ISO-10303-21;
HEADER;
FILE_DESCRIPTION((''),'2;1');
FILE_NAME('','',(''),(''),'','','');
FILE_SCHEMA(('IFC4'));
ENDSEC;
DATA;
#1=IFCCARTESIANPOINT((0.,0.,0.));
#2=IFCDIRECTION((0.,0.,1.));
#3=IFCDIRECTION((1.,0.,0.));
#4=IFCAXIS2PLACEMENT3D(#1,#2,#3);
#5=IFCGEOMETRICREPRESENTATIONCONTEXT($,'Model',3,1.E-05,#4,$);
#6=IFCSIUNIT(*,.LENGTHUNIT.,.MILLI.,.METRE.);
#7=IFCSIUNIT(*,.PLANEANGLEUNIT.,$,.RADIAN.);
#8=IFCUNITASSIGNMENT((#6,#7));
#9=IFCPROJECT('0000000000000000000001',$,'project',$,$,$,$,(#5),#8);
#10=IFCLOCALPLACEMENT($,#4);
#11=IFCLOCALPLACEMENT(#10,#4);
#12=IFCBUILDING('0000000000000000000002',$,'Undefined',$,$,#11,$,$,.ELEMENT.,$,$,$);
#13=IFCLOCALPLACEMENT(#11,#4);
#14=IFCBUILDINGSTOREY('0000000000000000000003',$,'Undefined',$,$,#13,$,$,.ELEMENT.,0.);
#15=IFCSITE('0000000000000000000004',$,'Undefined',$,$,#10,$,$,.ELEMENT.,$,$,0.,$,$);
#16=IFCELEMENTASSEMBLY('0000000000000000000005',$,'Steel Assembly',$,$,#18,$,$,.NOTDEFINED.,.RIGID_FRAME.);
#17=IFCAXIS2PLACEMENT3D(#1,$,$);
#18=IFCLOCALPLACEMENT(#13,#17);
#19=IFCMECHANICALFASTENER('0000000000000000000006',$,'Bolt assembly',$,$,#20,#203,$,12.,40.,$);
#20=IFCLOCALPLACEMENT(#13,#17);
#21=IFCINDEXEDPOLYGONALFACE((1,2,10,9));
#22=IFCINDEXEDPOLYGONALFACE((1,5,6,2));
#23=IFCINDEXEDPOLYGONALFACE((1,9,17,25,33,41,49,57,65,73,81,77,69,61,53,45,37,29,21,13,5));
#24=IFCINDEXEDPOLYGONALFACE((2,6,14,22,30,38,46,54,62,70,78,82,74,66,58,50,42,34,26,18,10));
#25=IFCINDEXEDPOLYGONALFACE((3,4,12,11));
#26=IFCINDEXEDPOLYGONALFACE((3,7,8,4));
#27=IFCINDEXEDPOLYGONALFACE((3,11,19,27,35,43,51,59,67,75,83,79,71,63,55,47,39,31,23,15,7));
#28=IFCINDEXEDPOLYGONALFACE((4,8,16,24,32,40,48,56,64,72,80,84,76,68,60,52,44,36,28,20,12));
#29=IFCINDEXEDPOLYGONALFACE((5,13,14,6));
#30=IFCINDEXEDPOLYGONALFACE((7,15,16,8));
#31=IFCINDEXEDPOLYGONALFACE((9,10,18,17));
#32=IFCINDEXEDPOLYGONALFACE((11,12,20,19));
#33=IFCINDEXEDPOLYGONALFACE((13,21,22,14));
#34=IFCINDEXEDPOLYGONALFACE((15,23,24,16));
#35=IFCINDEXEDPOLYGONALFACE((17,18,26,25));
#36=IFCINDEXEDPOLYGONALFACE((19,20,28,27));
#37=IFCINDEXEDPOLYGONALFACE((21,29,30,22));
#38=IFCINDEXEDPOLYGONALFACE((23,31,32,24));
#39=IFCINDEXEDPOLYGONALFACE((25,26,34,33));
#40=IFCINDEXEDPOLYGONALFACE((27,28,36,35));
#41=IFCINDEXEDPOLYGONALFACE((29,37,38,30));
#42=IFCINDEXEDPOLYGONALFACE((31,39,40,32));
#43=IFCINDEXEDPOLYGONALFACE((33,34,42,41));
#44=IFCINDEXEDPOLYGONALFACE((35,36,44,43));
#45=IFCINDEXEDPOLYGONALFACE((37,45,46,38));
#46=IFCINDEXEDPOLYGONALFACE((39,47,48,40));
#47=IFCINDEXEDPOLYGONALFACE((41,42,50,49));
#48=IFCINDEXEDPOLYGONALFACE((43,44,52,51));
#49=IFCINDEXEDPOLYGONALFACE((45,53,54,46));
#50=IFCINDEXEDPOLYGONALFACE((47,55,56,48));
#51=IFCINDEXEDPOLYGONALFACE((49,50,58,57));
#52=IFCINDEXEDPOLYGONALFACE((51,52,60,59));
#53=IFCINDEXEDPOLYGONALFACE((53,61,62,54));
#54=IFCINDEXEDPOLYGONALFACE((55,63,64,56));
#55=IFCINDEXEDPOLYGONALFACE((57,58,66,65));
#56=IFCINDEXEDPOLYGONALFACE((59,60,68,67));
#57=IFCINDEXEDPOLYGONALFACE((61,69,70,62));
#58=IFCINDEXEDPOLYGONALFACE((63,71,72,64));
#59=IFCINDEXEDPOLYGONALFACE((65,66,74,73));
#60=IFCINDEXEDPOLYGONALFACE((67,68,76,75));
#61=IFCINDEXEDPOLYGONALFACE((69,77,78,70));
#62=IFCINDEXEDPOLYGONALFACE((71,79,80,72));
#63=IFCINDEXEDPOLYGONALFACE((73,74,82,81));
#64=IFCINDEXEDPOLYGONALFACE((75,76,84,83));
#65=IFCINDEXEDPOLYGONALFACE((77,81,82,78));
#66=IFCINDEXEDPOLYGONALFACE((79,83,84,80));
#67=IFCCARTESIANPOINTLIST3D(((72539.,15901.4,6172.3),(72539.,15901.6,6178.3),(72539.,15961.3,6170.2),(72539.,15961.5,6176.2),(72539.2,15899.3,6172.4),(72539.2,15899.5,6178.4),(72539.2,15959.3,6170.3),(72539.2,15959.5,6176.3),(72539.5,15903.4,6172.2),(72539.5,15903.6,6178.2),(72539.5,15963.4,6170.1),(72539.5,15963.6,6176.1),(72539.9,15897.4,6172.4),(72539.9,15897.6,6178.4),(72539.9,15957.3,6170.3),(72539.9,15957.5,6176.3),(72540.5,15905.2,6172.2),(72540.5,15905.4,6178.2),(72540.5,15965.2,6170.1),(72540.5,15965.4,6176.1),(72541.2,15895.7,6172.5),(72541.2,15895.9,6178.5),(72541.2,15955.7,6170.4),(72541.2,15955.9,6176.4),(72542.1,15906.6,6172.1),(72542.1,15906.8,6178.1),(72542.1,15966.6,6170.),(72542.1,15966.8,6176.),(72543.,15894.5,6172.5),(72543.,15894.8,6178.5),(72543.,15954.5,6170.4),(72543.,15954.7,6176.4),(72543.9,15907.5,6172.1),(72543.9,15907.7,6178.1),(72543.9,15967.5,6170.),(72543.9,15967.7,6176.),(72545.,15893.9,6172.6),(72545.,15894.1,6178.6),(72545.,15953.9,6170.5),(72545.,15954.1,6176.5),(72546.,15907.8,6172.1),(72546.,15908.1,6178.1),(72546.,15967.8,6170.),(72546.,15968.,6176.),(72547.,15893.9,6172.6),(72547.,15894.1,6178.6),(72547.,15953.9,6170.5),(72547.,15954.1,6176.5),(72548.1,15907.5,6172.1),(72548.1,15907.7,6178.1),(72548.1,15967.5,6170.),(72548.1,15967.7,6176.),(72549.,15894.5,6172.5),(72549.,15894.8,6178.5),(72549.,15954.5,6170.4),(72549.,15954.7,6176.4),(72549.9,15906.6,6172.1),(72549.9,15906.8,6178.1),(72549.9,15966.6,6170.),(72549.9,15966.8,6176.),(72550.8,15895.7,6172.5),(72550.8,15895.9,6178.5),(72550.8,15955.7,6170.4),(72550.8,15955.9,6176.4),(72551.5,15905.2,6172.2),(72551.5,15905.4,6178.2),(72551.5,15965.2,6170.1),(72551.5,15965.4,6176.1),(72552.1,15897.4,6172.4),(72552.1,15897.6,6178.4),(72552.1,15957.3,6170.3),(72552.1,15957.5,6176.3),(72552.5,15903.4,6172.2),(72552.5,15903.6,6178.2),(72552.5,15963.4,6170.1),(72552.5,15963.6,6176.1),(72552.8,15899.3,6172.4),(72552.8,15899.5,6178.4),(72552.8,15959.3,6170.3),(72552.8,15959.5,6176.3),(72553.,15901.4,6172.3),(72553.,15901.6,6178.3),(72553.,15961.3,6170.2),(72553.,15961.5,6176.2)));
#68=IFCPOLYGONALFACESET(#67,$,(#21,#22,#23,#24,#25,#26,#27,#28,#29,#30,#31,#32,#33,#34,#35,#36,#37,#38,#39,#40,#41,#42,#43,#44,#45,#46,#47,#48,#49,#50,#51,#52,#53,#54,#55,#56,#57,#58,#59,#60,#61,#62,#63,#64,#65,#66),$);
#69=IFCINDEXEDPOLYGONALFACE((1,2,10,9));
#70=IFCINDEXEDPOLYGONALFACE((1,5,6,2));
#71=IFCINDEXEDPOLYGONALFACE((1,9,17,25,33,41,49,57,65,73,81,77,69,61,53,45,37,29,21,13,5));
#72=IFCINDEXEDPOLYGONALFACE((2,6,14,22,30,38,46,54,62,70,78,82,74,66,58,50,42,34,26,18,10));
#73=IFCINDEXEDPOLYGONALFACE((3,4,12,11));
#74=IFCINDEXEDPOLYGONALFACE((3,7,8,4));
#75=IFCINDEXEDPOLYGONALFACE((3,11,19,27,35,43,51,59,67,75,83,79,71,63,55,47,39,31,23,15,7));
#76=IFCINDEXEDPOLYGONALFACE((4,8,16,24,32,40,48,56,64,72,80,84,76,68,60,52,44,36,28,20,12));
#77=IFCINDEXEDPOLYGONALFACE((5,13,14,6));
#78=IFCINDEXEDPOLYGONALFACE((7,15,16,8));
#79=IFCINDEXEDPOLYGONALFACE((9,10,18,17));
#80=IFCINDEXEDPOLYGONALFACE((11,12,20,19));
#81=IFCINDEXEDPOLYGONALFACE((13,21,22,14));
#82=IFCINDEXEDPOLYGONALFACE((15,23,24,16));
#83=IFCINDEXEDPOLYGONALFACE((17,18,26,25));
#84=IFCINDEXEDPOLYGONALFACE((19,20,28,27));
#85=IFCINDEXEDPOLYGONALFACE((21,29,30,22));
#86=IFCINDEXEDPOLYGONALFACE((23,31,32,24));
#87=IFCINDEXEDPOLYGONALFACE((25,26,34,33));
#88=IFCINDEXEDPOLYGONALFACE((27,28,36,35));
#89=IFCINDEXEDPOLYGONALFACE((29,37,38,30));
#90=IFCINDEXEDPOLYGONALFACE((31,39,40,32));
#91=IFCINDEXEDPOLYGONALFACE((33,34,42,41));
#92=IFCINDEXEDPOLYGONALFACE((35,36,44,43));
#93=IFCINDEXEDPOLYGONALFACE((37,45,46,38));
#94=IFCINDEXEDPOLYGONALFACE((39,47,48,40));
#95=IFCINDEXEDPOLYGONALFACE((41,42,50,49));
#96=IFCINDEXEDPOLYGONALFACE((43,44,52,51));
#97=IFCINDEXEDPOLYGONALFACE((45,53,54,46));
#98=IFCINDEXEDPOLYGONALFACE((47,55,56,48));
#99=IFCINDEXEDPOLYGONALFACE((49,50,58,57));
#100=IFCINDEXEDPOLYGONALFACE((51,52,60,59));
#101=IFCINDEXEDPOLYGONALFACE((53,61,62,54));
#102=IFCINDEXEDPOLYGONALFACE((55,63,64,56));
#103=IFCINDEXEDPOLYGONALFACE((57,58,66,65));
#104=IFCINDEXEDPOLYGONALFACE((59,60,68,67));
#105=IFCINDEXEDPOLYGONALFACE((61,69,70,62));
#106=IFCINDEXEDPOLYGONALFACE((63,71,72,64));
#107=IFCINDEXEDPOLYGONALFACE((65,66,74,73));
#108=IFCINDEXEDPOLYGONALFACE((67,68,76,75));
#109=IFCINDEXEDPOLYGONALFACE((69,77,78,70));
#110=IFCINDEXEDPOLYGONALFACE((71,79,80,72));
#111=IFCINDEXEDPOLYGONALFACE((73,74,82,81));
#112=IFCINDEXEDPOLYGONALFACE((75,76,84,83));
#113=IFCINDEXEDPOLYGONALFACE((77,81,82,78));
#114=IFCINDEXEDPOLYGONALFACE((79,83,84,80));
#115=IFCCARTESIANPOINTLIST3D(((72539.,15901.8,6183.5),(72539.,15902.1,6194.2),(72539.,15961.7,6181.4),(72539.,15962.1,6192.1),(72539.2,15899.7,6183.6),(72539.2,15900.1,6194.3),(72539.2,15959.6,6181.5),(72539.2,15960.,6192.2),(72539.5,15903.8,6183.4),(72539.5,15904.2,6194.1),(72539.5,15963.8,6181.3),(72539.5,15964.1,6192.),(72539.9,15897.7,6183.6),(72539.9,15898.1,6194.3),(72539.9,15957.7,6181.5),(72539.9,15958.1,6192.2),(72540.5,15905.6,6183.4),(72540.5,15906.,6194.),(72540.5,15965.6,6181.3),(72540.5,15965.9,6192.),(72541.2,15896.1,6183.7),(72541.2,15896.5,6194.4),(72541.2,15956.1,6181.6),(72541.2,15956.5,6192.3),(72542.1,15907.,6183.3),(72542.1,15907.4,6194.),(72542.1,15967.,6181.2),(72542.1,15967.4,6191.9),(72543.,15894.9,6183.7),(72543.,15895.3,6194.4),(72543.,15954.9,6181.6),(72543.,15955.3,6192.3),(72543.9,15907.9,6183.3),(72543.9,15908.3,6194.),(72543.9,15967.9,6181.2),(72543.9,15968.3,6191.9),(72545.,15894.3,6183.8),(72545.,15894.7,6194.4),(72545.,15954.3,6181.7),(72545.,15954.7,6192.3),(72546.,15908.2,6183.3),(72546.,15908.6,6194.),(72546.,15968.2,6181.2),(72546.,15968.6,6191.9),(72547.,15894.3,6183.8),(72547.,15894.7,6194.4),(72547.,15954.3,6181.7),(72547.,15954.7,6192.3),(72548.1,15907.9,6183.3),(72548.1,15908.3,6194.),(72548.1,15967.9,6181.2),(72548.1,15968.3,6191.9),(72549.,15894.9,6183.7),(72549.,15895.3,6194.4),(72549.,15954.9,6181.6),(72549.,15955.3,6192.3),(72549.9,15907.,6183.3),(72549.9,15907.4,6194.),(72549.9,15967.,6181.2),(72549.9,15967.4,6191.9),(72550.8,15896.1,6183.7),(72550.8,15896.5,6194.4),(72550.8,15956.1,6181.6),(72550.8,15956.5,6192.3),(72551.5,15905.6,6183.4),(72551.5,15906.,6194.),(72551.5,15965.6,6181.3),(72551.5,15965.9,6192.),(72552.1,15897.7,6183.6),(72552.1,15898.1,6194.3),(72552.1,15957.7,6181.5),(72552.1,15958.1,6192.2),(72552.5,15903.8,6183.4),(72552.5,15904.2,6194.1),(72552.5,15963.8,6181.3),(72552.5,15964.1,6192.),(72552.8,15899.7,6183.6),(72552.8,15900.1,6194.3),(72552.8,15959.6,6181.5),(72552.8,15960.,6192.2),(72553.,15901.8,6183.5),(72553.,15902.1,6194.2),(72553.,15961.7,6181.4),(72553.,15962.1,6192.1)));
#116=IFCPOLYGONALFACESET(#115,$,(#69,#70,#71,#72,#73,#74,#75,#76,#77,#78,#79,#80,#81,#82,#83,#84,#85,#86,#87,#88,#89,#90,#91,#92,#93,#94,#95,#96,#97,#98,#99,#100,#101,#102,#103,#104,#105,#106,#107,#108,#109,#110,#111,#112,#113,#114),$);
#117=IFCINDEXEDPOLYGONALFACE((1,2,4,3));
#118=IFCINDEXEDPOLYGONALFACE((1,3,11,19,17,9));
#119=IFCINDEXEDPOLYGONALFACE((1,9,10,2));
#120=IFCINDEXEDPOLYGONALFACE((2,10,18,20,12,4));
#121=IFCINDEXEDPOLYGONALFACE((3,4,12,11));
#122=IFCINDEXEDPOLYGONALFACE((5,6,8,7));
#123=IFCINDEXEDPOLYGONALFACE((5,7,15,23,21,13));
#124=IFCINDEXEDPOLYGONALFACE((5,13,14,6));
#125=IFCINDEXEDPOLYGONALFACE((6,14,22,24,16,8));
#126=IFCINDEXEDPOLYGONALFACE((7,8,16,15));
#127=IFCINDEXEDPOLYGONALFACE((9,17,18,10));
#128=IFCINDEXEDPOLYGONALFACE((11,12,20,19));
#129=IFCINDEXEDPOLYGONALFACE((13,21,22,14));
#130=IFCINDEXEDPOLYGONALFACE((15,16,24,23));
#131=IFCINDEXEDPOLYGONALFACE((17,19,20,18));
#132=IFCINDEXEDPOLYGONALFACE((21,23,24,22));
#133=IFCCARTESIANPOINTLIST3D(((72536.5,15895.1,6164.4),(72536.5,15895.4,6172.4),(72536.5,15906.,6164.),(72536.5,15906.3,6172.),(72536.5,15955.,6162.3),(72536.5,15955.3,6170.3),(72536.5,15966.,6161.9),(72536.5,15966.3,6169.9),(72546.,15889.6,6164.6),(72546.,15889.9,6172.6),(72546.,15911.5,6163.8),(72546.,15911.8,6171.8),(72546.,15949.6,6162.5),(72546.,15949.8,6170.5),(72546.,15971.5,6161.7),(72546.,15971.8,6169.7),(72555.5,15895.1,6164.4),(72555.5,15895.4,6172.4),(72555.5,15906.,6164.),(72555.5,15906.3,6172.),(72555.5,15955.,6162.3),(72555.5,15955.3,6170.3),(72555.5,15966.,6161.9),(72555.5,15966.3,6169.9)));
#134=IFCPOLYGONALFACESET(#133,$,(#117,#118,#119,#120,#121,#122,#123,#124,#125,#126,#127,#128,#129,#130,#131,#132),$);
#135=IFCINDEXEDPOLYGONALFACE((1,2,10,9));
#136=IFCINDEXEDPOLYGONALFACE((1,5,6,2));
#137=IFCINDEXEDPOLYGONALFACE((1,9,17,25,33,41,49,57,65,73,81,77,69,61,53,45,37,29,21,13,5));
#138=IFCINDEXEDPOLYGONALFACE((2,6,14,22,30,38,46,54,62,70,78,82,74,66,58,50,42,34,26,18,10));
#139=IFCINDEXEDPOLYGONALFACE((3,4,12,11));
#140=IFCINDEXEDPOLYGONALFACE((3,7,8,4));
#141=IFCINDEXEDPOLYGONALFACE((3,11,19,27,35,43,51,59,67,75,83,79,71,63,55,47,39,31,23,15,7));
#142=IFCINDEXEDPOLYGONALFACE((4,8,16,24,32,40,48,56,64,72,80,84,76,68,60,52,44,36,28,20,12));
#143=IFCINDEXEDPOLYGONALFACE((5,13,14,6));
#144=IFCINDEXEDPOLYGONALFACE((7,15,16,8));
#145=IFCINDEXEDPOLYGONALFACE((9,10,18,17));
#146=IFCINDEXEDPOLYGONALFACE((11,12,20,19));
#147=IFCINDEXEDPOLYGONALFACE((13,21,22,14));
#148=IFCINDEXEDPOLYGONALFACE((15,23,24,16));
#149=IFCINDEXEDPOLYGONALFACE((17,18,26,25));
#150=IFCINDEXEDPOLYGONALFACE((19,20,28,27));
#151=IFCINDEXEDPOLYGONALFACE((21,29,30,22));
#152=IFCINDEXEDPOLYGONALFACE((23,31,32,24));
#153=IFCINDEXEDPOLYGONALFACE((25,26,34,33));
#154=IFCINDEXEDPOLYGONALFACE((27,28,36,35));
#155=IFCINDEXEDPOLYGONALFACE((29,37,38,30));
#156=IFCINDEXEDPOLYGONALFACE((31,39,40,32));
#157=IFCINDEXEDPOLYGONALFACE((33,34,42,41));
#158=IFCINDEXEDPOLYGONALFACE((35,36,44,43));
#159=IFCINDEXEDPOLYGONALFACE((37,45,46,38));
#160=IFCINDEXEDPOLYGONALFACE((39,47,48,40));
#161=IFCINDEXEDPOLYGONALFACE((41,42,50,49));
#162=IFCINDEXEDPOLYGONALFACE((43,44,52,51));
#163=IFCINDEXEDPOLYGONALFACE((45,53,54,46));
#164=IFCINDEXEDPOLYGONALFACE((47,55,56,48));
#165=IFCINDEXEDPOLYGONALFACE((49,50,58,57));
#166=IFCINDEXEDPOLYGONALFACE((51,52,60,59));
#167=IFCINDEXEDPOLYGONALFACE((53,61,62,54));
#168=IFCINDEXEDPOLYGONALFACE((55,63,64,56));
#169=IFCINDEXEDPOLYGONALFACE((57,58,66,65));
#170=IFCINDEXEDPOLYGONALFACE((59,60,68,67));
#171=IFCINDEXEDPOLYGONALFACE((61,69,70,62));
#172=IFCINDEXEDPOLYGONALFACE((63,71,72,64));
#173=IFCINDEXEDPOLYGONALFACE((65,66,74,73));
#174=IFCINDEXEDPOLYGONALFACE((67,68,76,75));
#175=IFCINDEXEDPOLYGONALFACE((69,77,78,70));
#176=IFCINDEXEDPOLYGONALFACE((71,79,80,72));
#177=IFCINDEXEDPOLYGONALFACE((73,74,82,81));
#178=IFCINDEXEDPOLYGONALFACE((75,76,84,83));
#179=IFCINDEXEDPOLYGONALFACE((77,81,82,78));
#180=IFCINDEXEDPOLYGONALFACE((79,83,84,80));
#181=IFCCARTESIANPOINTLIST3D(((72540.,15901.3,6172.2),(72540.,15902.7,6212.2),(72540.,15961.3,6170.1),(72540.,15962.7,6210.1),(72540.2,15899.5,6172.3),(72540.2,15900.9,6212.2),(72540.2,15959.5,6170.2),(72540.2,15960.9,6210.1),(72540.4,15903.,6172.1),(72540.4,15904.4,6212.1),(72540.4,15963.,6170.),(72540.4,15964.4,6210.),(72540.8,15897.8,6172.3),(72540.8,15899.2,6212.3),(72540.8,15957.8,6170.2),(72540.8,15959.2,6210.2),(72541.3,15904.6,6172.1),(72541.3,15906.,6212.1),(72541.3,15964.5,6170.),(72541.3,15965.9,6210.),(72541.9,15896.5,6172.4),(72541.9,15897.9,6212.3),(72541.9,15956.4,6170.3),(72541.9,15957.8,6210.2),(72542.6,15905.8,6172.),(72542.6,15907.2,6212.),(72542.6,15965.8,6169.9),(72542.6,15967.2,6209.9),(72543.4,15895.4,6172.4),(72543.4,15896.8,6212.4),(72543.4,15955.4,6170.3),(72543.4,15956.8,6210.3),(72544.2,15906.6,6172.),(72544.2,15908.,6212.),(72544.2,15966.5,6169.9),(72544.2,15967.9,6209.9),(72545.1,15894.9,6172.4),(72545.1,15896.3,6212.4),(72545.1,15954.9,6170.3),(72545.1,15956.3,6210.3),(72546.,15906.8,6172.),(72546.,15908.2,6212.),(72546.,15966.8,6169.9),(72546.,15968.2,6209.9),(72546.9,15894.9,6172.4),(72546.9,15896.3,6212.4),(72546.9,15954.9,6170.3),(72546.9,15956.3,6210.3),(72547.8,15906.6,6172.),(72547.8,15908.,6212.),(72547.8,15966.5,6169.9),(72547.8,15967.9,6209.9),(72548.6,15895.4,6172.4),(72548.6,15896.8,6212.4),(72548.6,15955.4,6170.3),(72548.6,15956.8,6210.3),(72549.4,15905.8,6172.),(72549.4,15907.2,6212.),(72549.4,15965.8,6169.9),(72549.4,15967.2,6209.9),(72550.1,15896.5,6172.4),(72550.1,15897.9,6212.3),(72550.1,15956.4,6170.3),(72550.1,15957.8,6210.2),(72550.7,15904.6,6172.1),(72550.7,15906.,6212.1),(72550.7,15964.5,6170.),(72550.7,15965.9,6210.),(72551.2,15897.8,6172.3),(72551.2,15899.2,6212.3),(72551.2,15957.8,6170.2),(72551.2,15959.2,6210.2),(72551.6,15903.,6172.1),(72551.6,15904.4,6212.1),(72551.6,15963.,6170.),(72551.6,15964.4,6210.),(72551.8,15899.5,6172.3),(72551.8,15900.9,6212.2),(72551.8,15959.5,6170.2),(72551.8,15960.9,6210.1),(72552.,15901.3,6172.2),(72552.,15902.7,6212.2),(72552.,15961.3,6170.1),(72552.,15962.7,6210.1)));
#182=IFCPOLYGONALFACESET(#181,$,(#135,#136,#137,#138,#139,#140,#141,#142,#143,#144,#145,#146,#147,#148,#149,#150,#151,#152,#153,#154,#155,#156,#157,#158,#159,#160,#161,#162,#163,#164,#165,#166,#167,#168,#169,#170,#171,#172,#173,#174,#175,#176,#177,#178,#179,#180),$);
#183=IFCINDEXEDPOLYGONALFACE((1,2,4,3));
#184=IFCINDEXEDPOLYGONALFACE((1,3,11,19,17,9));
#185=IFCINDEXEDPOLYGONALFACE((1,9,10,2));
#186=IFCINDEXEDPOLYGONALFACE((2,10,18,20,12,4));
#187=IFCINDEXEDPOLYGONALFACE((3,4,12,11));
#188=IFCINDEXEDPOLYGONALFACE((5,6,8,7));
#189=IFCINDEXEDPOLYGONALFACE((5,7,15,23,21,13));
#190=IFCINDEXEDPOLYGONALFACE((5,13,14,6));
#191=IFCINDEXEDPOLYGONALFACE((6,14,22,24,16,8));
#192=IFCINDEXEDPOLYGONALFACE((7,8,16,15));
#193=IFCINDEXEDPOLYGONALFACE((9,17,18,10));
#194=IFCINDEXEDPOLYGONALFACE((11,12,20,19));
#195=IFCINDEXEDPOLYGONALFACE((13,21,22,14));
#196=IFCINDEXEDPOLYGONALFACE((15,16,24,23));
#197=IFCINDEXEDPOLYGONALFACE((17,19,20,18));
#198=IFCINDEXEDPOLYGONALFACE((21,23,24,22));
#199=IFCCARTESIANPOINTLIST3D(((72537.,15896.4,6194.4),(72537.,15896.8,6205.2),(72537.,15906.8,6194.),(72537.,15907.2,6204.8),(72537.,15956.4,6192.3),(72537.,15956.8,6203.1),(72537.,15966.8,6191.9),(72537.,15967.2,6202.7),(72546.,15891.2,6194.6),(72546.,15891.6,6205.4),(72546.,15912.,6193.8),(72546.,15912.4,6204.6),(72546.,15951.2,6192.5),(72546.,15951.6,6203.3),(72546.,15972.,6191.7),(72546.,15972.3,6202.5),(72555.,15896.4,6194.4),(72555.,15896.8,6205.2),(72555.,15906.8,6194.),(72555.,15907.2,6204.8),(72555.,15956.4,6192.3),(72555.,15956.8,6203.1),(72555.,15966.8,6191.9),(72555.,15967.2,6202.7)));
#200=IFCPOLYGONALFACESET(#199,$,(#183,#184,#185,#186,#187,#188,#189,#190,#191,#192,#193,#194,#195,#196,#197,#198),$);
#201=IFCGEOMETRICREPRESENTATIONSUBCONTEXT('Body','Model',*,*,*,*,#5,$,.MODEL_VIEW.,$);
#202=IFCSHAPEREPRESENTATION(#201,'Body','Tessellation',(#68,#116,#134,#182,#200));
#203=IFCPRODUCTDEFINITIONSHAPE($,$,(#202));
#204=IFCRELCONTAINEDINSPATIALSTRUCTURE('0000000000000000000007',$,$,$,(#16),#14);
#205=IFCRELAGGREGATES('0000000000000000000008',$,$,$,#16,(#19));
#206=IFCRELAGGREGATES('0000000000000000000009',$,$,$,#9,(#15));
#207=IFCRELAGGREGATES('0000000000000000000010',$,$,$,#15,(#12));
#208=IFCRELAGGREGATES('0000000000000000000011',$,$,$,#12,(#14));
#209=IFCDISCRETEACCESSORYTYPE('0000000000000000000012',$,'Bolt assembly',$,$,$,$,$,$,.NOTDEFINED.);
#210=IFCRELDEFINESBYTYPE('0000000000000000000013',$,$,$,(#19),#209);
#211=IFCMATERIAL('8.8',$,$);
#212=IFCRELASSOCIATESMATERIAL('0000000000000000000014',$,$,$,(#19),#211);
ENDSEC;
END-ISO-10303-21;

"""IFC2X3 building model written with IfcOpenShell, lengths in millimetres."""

from ifc_helpers import new_model, si_unit, frame, origin_with_axes, origin_2d_with_axis, place, context, subcontext, project, spatial, polyline, circle, outline, extrude, source, transform, mapped, material, type_object, element, aggregate, save


model = new_model("IFC2X3")

# Units and contexts
model_context = context("Model", 3, precision=1e-05, world=origin_with_axes())
body_context = subcontext(model_context, "Body", "Model", "MODEL_VIEW")
ifc_project = project(units=[si_unit("LENGTHUNIT", "METRE", prefix="MILLI"), si_unit("PLANEANGLEUNIT", "RADIAN")], contexts=[model_context])

# Site, building, storey
site_placement = place(None, origin_with_axes())
site = spatial("IfcSite", under=ifc_project, at=site_placement, Name="Undefined", CompositionType="ELEMENT", RefElevation=0.0)
building_placement = place(site_placement, origin_with_axes())
building = spatial("IfcBuilding", under=site, at=building_placement, Name="Undefined", CompositionType="ELEMENT")
storey_placement = place(building_placement, origin_with_axes())
storey = spatial("IfcBuildingStorey", under=building, at=storey_placement, Name="Undefined", CompositionType="ELEMENT", Elevation=0.0)

# Element assembly
assembly_1_placement = place(storey_placement, origin_with_axes())
assembly_1 = element("IfcElementAssembly", 1, at=assembly_1_placement, inside=storey, Name="Steel Assembly", AssemblyPlace="NOTDEFINED", PredefinedType="RIGID_FRAME")

# Shared definitions
discrete_accessory_type_1 = type_object("IfcDiscreteAccessoryType", Name="Bolt assembly")
ifc_material_1 = material(Name="8.8")

# Mechanical fastener
shared_shape_1 = source(origin_with_axes(), body_context, "Body", "SweptSolid", [
    extrude(circle(Radius=7.0, at=origin_2d_with_axis()), frame((0.0, -2.9, 0.0), z_axis=(0.0, 1.0, 0.0), x_axis=(1.0, 0.0, 0.0)), (0.0, 0.0, 1.0), 6.0),
    extrude(circle(Radius=7.0, at=origin_2d_with_axis()), frame((0.0, 8.3, 0.0), z_axis=(0.0, 1.0, 0.0), x_axis=(1.0, 0.0, 0.0)), (0.0, 0.0, 1.0), 10.7),
    extrude(outline(polyline([(11.0, 0.0), (5.5, 9.5), (-5.5, 9.5), (-11.0, 0.0), (-5.5, -9.5), (5.5, -9.5), (11.0, 0.0)])), frame((0.0, -11.0, 0.0), z_axis=(0.0, 1.0, 0.0), x_axis=(1.0, 0.0, 0.0)), (0.0, 0.0, 1.0), 8.0),
    extrude(circle(Radius=6.0, at=origin_2d_with_axis()), frame((0.0, -3.0, 0.0), z_axis=(0.0, 1.0, 0.0), x_axis=(1.0, 0.0, 0.0)), (0.0, 0.0, 1.0), 40.0),
    extrude(outline(polyline([(10.4, 0.0), (5.2, 9.0), (-5.2, 9.0), (-10.4, 0.0), (-5.2, -9.0), (5.2, -9.0), (10.4, 0.0)])), frame((0.0, 19.0, 0.0), z_axis=(0.0, 1.0, 0.0), x_axis=(1.0, 0.0, 0.0)), (0.0, 0.0, 1.0), 10.8),
])
mechanical_fastener_1_placement = place(assembly_1_placement, frame((72546.0, 15901.0, 6175.2), z_axis=(1.0, 0.0, 0.0), x_axis=(0.0, 0.999388, -0.034978)))
mechanical_fastener_1 = element("IfcMechanicalFastener", 2, at=mechanical_fastener_1_placement, type_object=discrete_accessory_type_1, material=ifc_material_1, Name="Bolt assembly", NominalDiameter=12.0, NominalLength=40.0, context=body_context, shape_type="MappedRepresentation", body=[
    mapped(shared_shape_1, transform((0.0, 0.0, 0.0))),
    mapped(shared_shape_1, transform((60.0, 0.0, 0.0))),
])
aggregate(assembly_1, [mechanical_fastener_1])

save(model, "model.ifc")
